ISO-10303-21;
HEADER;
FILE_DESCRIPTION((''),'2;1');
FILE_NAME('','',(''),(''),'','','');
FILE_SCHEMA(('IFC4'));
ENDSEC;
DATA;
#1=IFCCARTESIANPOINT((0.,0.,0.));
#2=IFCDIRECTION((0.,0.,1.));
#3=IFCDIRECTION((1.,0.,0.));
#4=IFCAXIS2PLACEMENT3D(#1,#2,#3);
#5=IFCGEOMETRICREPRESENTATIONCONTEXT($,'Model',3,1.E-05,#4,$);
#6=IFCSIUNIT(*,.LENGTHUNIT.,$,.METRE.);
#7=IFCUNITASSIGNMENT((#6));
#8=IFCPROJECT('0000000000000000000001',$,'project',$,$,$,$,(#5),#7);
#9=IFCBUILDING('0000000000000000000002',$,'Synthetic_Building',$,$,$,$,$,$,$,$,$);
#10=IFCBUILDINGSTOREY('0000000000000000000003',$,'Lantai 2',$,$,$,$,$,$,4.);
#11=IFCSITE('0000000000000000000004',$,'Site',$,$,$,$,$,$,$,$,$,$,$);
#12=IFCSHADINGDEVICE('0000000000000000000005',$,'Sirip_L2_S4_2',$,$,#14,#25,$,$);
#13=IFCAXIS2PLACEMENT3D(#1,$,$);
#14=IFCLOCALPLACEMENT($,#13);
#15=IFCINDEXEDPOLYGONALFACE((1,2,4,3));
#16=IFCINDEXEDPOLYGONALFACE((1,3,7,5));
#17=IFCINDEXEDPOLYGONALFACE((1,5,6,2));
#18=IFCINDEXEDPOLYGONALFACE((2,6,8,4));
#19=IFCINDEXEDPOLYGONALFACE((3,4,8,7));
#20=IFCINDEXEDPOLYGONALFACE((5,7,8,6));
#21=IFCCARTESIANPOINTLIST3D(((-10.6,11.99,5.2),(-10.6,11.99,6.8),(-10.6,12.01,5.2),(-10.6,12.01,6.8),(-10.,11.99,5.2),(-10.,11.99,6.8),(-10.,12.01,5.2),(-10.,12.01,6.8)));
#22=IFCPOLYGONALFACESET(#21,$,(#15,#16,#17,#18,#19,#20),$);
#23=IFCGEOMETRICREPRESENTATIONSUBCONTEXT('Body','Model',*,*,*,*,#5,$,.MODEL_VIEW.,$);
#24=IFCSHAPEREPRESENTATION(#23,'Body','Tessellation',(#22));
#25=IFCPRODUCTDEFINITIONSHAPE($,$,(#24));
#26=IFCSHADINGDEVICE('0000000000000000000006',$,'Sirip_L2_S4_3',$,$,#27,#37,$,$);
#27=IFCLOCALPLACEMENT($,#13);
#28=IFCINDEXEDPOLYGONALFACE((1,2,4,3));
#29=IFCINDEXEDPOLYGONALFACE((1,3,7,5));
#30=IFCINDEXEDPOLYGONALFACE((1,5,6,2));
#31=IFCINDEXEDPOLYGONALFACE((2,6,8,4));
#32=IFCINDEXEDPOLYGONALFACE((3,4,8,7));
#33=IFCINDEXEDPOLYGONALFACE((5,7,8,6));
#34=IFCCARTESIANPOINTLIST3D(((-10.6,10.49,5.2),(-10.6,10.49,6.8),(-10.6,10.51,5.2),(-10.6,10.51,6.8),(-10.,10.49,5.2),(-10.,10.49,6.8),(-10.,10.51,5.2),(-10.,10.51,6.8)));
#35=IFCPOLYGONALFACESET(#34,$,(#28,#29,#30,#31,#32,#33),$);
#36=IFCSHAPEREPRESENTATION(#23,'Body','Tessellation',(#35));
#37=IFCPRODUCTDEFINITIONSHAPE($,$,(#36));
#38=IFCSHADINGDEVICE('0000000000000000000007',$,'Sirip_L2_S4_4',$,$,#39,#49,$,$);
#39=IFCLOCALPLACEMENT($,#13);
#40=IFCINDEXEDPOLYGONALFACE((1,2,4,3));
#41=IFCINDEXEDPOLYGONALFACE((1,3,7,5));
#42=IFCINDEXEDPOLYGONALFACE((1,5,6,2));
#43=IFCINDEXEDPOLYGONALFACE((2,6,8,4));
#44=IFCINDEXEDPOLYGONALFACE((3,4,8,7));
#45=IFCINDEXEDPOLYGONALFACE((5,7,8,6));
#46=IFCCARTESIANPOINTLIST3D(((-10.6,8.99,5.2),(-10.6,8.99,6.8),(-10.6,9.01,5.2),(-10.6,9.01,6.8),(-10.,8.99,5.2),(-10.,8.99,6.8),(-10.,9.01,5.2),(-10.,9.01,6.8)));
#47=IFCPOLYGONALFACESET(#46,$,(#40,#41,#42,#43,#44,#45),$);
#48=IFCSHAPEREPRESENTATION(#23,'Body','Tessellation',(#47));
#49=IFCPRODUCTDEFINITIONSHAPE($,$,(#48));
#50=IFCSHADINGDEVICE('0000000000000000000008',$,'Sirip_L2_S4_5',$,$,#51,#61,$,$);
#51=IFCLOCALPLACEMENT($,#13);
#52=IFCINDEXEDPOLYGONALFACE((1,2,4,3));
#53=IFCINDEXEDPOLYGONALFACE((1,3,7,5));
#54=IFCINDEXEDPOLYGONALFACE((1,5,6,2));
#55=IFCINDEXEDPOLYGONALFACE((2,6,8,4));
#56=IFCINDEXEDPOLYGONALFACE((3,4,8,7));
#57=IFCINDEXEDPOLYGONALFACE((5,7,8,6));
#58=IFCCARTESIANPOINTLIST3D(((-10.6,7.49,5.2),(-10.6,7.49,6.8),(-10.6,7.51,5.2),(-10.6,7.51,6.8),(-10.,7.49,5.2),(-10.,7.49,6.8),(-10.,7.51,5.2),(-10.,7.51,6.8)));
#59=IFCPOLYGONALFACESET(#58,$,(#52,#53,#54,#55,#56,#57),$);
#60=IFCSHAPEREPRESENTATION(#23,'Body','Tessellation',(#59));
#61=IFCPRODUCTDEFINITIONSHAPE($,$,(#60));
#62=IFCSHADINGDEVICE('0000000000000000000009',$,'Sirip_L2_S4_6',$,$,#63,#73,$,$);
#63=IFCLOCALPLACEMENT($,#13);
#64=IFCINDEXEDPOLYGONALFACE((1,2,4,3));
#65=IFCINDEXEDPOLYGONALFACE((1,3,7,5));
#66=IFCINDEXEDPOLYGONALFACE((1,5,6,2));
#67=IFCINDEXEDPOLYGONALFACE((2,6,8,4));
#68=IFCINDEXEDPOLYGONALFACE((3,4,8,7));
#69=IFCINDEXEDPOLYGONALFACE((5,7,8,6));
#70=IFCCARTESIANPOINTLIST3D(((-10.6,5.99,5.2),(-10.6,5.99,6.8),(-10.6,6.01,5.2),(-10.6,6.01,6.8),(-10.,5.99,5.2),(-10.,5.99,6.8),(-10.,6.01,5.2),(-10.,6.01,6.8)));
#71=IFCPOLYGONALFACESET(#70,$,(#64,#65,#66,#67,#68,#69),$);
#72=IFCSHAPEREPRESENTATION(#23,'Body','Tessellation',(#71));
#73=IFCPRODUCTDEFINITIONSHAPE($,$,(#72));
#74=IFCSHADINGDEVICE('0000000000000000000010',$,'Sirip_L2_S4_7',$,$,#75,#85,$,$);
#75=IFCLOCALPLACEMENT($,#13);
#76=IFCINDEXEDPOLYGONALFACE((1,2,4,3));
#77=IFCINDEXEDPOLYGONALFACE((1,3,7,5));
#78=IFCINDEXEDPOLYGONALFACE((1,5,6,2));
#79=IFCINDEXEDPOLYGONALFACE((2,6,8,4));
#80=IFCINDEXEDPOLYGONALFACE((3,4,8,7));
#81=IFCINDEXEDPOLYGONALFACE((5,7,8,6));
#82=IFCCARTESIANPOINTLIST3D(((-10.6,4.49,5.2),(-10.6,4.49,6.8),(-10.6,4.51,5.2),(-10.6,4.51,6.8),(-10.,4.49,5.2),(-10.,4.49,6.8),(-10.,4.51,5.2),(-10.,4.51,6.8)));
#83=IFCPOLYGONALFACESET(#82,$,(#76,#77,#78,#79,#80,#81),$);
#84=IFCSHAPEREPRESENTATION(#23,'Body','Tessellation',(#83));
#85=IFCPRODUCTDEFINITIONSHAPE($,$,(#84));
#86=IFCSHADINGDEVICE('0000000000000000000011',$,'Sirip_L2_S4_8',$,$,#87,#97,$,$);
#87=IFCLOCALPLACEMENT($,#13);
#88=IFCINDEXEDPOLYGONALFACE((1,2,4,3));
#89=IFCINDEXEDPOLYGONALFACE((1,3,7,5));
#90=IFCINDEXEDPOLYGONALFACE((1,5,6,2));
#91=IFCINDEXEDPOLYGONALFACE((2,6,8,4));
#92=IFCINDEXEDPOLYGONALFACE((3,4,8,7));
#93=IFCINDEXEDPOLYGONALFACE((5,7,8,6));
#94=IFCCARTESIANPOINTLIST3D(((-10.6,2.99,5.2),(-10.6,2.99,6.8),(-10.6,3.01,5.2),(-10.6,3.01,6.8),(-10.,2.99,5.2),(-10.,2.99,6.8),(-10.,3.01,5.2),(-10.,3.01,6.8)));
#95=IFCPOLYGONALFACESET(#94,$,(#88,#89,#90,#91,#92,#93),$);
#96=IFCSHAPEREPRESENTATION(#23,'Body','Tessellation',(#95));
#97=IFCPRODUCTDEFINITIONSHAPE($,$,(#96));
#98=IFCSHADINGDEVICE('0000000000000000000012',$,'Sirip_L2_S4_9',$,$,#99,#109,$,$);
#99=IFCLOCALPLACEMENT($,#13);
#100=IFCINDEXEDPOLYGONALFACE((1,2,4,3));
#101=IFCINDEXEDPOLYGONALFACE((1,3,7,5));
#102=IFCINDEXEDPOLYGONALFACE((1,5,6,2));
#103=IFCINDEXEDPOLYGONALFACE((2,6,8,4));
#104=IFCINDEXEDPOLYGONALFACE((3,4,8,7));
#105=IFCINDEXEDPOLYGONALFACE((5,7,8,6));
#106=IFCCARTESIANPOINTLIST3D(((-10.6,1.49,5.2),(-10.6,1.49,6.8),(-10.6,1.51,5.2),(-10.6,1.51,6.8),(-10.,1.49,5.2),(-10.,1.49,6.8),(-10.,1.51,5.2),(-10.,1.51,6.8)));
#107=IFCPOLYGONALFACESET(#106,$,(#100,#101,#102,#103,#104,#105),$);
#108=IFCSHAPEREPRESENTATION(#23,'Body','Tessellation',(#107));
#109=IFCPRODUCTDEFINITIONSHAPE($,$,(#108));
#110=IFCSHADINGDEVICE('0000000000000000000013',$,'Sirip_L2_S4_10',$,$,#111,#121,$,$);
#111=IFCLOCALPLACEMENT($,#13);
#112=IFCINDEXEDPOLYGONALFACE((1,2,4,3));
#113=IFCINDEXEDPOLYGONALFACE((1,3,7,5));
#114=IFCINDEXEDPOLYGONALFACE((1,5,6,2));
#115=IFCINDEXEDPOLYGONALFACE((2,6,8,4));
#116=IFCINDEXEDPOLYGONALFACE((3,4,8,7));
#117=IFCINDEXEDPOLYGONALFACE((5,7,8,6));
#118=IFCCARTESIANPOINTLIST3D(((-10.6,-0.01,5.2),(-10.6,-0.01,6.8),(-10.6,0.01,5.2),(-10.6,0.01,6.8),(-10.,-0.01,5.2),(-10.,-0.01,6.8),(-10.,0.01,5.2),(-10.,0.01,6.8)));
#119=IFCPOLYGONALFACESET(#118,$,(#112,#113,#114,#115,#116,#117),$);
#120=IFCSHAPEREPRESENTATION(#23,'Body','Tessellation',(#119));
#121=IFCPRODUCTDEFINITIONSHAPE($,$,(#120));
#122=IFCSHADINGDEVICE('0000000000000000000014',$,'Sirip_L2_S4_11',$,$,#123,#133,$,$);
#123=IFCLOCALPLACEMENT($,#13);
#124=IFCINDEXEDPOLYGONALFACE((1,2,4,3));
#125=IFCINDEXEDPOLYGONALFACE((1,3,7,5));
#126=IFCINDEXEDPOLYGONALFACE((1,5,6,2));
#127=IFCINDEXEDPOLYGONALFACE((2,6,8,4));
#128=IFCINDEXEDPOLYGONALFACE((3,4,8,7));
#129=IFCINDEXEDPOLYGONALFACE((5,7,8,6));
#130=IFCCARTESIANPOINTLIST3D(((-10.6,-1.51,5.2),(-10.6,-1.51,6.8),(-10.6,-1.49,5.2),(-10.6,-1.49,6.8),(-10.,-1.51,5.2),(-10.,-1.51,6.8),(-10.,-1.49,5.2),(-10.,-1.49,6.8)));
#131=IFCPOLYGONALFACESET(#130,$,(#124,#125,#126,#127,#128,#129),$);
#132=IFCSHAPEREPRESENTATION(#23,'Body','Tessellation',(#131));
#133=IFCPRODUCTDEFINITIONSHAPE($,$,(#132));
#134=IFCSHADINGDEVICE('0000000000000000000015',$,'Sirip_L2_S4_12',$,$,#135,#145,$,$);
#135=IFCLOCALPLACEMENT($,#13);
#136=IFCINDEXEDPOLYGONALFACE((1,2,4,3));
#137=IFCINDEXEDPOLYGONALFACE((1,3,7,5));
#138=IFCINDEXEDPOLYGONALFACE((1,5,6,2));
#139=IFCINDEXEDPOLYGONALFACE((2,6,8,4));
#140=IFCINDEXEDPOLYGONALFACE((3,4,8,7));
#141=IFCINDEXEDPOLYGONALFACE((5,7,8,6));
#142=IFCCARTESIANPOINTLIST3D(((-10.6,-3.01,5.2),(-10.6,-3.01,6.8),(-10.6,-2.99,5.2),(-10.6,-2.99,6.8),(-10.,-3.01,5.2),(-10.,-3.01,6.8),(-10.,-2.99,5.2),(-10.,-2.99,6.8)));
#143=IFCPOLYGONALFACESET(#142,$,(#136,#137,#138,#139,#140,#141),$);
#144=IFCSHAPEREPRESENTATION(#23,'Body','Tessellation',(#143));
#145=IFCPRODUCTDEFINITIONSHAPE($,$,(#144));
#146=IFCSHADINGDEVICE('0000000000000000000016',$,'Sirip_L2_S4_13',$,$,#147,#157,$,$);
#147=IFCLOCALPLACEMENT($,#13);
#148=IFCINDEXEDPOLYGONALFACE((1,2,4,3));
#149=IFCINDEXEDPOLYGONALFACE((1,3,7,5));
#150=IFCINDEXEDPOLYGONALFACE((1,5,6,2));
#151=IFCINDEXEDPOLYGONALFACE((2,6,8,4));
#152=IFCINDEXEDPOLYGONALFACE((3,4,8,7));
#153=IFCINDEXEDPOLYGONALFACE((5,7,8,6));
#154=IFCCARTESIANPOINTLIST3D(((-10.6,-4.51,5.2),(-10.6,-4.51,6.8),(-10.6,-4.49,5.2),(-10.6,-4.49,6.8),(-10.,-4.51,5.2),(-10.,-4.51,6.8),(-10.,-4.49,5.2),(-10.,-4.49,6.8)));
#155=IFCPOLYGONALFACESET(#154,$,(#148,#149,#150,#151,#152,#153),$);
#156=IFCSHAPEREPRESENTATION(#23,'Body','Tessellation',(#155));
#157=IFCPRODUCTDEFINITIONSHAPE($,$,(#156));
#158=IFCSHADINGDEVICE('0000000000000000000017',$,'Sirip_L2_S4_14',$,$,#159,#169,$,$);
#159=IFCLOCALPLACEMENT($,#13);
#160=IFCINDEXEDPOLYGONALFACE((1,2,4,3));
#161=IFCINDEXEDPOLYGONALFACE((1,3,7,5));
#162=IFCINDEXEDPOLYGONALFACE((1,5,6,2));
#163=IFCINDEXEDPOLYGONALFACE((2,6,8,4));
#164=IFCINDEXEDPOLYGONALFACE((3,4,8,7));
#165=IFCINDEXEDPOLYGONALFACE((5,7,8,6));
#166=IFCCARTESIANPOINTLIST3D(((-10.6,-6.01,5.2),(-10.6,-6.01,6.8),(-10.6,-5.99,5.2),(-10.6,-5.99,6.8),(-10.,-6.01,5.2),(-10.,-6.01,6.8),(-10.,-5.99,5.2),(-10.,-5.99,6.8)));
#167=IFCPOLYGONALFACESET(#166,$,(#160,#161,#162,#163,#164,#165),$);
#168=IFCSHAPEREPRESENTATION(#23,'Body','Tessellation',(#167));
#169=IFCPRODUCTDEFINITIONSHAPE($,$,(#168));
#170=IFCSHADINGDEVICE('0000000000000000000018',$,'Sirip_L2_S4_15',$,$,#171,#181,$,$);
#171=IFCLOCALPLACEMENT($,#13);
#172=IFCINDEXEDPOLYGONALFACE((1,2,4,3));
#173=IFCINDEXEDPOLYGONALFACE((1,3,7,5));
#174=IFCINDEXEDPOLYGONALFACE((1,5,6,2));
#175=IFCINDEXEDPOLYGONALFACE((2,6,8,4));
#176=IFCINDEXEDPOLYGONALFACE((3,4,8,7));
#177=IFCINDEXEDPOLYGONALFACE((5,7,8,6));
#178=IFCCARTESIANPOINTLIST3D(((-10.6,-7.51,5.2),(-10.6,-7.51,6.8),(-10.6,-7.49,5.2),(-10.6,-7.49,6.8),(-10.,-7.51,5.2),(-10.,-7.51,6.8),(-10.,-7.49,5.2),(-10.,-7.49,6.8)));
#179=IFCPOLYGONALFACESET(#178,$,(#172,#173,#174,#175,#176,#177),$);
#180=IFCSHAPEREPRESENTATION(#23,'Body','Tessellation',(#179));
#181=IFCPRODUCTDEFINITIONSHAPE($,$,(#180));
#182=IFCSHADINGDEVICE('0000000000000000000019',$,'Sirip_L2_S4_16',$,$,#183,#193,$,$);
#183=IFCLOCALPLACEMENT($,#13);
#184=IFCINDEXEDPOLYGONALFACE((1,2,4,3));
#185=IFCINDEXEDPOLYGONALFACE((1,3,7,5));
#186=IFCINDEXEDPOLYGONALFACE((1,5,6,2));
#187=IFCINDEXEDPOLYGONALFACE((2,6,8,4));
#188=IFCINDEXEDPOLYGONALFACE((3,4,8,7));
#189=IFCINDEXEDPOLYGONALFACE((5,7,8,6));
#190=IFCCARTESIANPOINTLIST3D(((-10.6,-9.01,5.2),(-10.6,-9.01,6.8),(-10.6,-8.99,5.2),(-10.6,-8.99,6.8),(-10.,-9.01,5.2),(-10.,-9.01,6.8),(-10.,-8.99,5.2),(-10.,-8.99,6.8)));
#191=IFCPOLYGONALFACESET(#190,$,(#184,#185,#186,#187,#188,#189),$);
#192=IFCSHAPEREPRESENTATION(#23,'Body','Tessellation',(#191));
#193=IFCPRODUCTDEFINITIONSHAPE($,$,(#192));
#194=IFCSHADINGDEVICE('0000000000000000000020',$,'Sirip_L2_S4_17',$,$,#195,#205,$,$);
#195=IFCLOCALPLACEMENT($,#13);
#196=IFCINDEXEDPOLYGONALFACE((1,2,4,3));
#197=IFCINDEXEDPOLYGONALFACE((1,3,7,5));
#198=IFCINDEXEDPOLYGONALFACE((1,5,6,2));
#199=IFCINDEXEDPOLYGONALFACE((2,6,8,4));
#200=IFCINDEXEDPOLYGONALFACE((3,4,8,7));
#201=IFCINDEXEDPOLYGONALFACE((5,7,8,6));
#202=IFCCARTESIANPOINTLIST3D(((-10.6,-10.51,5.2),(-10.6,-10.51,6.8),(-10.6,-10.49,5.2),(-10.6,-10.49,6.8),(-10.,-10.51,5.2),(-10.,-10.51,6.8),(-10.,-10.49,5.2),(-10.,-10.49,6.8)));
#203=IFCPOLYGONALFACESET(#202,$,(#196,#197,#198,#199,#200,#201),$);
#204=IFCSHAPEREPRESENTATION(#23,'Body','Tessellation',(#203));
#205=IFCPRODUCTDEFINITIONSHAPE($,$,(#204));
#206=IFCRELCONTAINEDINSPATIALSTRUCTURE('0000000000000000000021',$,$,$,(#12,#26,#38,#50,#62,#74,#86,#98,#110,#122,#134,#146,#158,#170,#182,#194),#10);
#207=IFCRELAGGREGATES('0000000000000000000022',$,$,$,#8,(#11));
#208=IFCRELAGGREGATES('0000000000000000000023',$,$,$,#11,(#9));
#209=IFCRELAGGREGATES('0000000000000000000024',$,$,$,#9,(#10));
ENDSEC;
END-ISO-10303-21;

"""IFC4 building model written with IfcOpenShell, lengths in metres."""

from ifc_helpers import new_model, si_unit, frame, origin_with_axes, place, context, subcontext, project, spatial, polyline, outline, extrude, element, save


model = new_model("IFC4")

# Units and contexts
model_context = context("Model", 3, precision=1e-05, world=origin_with_axes())
body_context = subcontext(model_context, "Body", "Model", "MODEL_VIEW")
ifc_project = project(units=[si_unit("LENGTHUNIT", "METRE")], contexts=[model_context])

# Site, building, storey
site = spatial("IfcSite", under=ifc_project, Name="Site")
building = spatial("IfcBuilding", under=site, Name="Synthetic_Building")
storey = spatial("IfcBuildingStorey", under=building, Name="Lantai 2", Elevation=4.0)

# Shading devices
shading_device_1_placement = place(None, origin_with_axes())
element("IfcShadingDevice", 1, at=shading_device_1_placement, inside=storey, Name="Sirip_L2_S4_2", context=body_context, shape_type="SweptSolid", body=[
    extrude(outline(polyline([(-10.0, 12.01), (-10.0, 11.99), (-10.6, 11.99), (-10.6, 12.01), (-10.0, 12.01)])), frame((0.0, 0.0, 5.2), z_axis=(0.0, 0.0, 1.0), x_axis=(1.0, 0.0, 0.0)), (0.0, 0.0, 1.0), 1.6),
])
shading_device_2_placement = place(None, origin_with_axes())
element("IfcShadingDevice", 2, at=shading_device_2_placement, inside=storey, Name="Sirip_L2_S4_3", context=body_context, shape_type="SweptSolid", body=[
    extrude(outline(polyline([(-10.0, 10.51), (-10.0, 10.49), (-10.6, 10.49), (-10.6, 10.51), (-10.0, 10.51)])), frame((0.0, 0.0, 5.2), z_axis=(0.0, 0.0, 1.0), x_axis=(1.0, 0.0, 0.0)), (0.0, 0.0, 1.0), 1.6),
])
shading_device_3_placement = place(None, origin_with_axes())
element("IfcShadingDevice", 3, at=shading_device_3_placement, inside=storey, Name="Sirip_L2_S4_4", context=body_context, shape_type="SweptSolid", body=[
    extrude(outline(polyline([(-10.0, 9.01), (-10.0, 8.99), (-10.6, 8.99), (-10.6, 9.01), (-10.0, 9.01)])), frame((0.0, 0.0, 5.2), z_axis=(0.0, 0.0, 1.0), x_axis=(1.0, 0.0, 0.0)), (0.0, 0.0, 1.0), 1.6),
])
shading_device_4_placement = place(None, origin_with_axes())
element("IfcShadingDevice", 4, at=shading_device_4_placement, inside=storey, Name="Sirip_L2_S4_5", context=body_context, shape_type="SweptSolid", body=[
    extrude(outline(polyline([(-10.0, 7.51), (-10.0, 7.49), (-10.6, 7.49), (-10.6, 7.51), (-10.0, 7.51)])), frame((0.0, 0.0, 5.2), z_axis=(0.0, 0.0, 1.0), x_axis=(1.0, 0.0, 0.0)), (0.0, 0.0, 1.0), 1.6),
])
shading_device_5_placement = place(None, origin_with_axes())
element("IfcShadingDevice", 5, at=shading_device_5_placement, inside=storey, Name="Sirip_L2_S4_6", context=body_context, shape_type="SweptSolid", body=[
    extrude(outline(polyline([(-10.0, 6.01), (-10.0, 5.99), (-10.6, 5.99), (-10.6, 6.01), (-10.0, 6.01)])), frame((0.0, 0.0, 5.2), z_axis=(0.0, 0.0, 1.0), x_axis=(1.0, 0.0, 0.0)), (0.0, 0.0, 1.0), 1.6),
])
shading_device_6_placement = place(None, origin_with_axes())
element("IfcShadingDevice", 6, at=shading_device_6_placement, inside=storey, Name="Sirip_L2_S4_7", context=body_context, shape_type="SweptSolid", body=[
    extrude(outline(polyline([(-10.0, 4.51), (-10.0, 4.49), (-10.6, 4.49), (-10.6, 4.51), (-10.0, 4.51)])), frame((0.0, 0.0, 5.2), z_axis=(0.0, 0.0, 1.0), x_axis=(1.0, 0.0, 0.0)), (0.0, 0.0, 1.0), 1.6),
])
shading_device_7_placement = place(None, origin_with_axes())
element("IfcShadingDevice", 7, at=shading_device_7_placement, inside=storey, Name="Sirip_L2_S4_8", context=body_context, shape_type="SweptSolid", body=[
    extrude(outline(polyline([(-10.0, 3.01), (-10.0, 2.99), (-10.6, 2.99), (-10.6, 3.01), (-10.0, 3.01)])), frame((0.0, 0.0, 5.2), z_axis=(0.0, 0.0, 1.0), x_axis=(1.0, 0.0, 0.0)), (0.0, 0.0, 1.0), 1.6),
])
shading_device_8_placement = place(None, origin_with_axes())
element("IfcShadingDevice", 8, at=shading_device_8_placement, inside=storey, Name="Sirip_L2_S4_9", context=body_context, shape_type="SweptSolid", body=[
    extrude(outline(polyline([(-10.0, 1.51), (-10.0, 1.49), (-10.6, 1.49), (-10.6, 1.51), (-10.0, 1.51)])), frame((0.0, 0.0, 5.2), z_axis=(0.0, 0.0, 1.0), x_axis=(1.0, 0.0, 0.0)), (0.0, 0.0, 1.0), 1.6),
])
shading_device_9_placement = place(None, origin_with_axes())
element("IfcShadingDevice", 9, at=shading_device_9_placement, inside=storey, Name="Sirip_L2_S4_10", context=body_context, shape_type="SweptSolid", body=[
    extrude(outline(polyline([(-10.0, 0.01), (-10.0, -0.01), (-10.6, -0.01), (-10.6, 0.01), (-10.0, 0.01)])), frame((0.0, 0.0, 5.2), z_axis=(0.0, 0.0, 1.0), x_axis=(1.0, 0.0, 0.0)), (0.0, 0.0, 1.0), 1.6),
])
shading_device_10_placement = place(None, origin_with_axes())
element("IfcShadingDevice", 10, at=shading_device_10_placement, inside=storey, Name="Sirip_L2_S4_11", context=body_context, shape_type="SweptSolid", body=[
    extrude(outline(polyline([(-10.0, -1.49), (-10.0, -1.51), (-10.6, -1.51), (-10.6, -1.49), (-10.0, -1.49)])), frame((0.0, 0.0, 5.2), z_axis=(0.0, 0.0, 1.0), x_axis=(1.0, 0.0, 0.0)), (0.0, 0.0, 1.0), 1.6),
])
shading_device_11_placement = place(None, origin_with_axes())
element("IfcShadingDevice", 11, at=shading_device_11_placement, inside=storey, Name="Sirip_L2_S4_12", context=body_context, shape_type="SweptSolid", body=[
    extrude(outline(polyline([(-10.0, -2.99), (-10.0, -3.01), (-10.6, -3.01), (-10.6, -2.99), (-10.0, -2.99)])), frame((0.0, 0.0, 5.2), z_axis=(0.0, 0.0, 1.0), x_axis=(1.0, 0.0, 0.0)), (0.0, 0.0, 1.0), 1.6),
])
shading_device_12_placement = place(None, origin_with_axes())
element("IfcShadingDevice", 12, at=shading_device_12_placement, inside=storey, Name="Sirip_L2_S4_13", context=body_context, shape_type="SweptSolid", body=[
    extrude(outline(polyline([(-10.0, -4.49), (-10.0, -4.51), (-10.6, -4.51), (-10.6, -4.49), (-10.0, -4.49)])), frame((0.0, 0.0, 5.2), z_axis=(0.0, 0.0, 1.0), x_axis=(1.0, 0.0, 0.0)), (0.0, 0.0, 1.0), 1.6),
])
shading_device_13_placement = place(None, origin_with_axes())
element("IfcShadingDevice", 13, at=shading_device_13_placement, inside=storey, Name="Sirip_L2_S4_14", context=body_context, shape_type="SweptSolid", body=[
    extrude(outline(polyline([(-10.0, -5.99), (-10.0, -6.01), (-10.6, -6.01), (-10.6, -5.99), (-10.0, -5.99)])), frame((0.0, 0.0, 5.2), z_axis=(0.0, 0.0, 1.0), x_axis=(1.0, 0.0, 0.0)), (0.0, 0.0, 1.0), 1.6),
])
shading_device_14_placement = place(None, origin_with_axes())
element("IfcShadingDevice", 14, at=shading_device_14_placement, inside=storey, Name="Sirip_L2_S4_15", context=body_context, shape_type="SweptSolid", body=[
    extrude(outline(polyline([(-10.0, -7.49), (-10.0, -7.51), (-10.6, -7.51), (-10.6, -7.49), (-10.0, -7.49)])), frame((0.0, 0.0, 5.2), z_axis=(0.0, 0.0, 1.0), x_axis=(1.0, 0.0, 0.0)), (0.0, 0.0, 1.0), 1.6),
])
shading_device_15_placement = place(None, origin_with_axes())
element("IfcShadingDevice", 15, at=shading_device_15_placement, inside=storey, Name="Sirip_L2_S4_16", context=body_context, shape_type="SweptSolid", body=[
    extrude(outline(polyline([(-10.0, -8.99), (-10.0, -9.01), (-10.6, -9.01), (-10.6, -8.99), (-10.0, -8.99)])), frame((0.0, 0.0, 5.2), z_axis=(0.0, 0.0, 1.0), x_axis=(1.0, 0.0, 0.0)), (0.0, 0.0, 1.0), 1.6),
])
shading_device_16_placement = place(None, origin_with_axes())
element("IfcShadingDevice", 16, at=shading_device_16_placement, inside=storey, Name="Sirip_L2_S4_17", context=body_context, shape_type="SweptSolid", body=[
    extrude(outline(polyline([(-10.0, -10.49), (-10.0, -10.51), (-10.6, -10.51), (-10.6, -10.49), (-10.0, -10.49)])), frame((0.0, 0.0, 5.2), z_axis=(0.0, 0.0, 1.0), x_axis=(1.0, 0.0, 0.0)), (0.0, 0.0, 1.0), 1.6),
])

save(model, "model.ifc")
